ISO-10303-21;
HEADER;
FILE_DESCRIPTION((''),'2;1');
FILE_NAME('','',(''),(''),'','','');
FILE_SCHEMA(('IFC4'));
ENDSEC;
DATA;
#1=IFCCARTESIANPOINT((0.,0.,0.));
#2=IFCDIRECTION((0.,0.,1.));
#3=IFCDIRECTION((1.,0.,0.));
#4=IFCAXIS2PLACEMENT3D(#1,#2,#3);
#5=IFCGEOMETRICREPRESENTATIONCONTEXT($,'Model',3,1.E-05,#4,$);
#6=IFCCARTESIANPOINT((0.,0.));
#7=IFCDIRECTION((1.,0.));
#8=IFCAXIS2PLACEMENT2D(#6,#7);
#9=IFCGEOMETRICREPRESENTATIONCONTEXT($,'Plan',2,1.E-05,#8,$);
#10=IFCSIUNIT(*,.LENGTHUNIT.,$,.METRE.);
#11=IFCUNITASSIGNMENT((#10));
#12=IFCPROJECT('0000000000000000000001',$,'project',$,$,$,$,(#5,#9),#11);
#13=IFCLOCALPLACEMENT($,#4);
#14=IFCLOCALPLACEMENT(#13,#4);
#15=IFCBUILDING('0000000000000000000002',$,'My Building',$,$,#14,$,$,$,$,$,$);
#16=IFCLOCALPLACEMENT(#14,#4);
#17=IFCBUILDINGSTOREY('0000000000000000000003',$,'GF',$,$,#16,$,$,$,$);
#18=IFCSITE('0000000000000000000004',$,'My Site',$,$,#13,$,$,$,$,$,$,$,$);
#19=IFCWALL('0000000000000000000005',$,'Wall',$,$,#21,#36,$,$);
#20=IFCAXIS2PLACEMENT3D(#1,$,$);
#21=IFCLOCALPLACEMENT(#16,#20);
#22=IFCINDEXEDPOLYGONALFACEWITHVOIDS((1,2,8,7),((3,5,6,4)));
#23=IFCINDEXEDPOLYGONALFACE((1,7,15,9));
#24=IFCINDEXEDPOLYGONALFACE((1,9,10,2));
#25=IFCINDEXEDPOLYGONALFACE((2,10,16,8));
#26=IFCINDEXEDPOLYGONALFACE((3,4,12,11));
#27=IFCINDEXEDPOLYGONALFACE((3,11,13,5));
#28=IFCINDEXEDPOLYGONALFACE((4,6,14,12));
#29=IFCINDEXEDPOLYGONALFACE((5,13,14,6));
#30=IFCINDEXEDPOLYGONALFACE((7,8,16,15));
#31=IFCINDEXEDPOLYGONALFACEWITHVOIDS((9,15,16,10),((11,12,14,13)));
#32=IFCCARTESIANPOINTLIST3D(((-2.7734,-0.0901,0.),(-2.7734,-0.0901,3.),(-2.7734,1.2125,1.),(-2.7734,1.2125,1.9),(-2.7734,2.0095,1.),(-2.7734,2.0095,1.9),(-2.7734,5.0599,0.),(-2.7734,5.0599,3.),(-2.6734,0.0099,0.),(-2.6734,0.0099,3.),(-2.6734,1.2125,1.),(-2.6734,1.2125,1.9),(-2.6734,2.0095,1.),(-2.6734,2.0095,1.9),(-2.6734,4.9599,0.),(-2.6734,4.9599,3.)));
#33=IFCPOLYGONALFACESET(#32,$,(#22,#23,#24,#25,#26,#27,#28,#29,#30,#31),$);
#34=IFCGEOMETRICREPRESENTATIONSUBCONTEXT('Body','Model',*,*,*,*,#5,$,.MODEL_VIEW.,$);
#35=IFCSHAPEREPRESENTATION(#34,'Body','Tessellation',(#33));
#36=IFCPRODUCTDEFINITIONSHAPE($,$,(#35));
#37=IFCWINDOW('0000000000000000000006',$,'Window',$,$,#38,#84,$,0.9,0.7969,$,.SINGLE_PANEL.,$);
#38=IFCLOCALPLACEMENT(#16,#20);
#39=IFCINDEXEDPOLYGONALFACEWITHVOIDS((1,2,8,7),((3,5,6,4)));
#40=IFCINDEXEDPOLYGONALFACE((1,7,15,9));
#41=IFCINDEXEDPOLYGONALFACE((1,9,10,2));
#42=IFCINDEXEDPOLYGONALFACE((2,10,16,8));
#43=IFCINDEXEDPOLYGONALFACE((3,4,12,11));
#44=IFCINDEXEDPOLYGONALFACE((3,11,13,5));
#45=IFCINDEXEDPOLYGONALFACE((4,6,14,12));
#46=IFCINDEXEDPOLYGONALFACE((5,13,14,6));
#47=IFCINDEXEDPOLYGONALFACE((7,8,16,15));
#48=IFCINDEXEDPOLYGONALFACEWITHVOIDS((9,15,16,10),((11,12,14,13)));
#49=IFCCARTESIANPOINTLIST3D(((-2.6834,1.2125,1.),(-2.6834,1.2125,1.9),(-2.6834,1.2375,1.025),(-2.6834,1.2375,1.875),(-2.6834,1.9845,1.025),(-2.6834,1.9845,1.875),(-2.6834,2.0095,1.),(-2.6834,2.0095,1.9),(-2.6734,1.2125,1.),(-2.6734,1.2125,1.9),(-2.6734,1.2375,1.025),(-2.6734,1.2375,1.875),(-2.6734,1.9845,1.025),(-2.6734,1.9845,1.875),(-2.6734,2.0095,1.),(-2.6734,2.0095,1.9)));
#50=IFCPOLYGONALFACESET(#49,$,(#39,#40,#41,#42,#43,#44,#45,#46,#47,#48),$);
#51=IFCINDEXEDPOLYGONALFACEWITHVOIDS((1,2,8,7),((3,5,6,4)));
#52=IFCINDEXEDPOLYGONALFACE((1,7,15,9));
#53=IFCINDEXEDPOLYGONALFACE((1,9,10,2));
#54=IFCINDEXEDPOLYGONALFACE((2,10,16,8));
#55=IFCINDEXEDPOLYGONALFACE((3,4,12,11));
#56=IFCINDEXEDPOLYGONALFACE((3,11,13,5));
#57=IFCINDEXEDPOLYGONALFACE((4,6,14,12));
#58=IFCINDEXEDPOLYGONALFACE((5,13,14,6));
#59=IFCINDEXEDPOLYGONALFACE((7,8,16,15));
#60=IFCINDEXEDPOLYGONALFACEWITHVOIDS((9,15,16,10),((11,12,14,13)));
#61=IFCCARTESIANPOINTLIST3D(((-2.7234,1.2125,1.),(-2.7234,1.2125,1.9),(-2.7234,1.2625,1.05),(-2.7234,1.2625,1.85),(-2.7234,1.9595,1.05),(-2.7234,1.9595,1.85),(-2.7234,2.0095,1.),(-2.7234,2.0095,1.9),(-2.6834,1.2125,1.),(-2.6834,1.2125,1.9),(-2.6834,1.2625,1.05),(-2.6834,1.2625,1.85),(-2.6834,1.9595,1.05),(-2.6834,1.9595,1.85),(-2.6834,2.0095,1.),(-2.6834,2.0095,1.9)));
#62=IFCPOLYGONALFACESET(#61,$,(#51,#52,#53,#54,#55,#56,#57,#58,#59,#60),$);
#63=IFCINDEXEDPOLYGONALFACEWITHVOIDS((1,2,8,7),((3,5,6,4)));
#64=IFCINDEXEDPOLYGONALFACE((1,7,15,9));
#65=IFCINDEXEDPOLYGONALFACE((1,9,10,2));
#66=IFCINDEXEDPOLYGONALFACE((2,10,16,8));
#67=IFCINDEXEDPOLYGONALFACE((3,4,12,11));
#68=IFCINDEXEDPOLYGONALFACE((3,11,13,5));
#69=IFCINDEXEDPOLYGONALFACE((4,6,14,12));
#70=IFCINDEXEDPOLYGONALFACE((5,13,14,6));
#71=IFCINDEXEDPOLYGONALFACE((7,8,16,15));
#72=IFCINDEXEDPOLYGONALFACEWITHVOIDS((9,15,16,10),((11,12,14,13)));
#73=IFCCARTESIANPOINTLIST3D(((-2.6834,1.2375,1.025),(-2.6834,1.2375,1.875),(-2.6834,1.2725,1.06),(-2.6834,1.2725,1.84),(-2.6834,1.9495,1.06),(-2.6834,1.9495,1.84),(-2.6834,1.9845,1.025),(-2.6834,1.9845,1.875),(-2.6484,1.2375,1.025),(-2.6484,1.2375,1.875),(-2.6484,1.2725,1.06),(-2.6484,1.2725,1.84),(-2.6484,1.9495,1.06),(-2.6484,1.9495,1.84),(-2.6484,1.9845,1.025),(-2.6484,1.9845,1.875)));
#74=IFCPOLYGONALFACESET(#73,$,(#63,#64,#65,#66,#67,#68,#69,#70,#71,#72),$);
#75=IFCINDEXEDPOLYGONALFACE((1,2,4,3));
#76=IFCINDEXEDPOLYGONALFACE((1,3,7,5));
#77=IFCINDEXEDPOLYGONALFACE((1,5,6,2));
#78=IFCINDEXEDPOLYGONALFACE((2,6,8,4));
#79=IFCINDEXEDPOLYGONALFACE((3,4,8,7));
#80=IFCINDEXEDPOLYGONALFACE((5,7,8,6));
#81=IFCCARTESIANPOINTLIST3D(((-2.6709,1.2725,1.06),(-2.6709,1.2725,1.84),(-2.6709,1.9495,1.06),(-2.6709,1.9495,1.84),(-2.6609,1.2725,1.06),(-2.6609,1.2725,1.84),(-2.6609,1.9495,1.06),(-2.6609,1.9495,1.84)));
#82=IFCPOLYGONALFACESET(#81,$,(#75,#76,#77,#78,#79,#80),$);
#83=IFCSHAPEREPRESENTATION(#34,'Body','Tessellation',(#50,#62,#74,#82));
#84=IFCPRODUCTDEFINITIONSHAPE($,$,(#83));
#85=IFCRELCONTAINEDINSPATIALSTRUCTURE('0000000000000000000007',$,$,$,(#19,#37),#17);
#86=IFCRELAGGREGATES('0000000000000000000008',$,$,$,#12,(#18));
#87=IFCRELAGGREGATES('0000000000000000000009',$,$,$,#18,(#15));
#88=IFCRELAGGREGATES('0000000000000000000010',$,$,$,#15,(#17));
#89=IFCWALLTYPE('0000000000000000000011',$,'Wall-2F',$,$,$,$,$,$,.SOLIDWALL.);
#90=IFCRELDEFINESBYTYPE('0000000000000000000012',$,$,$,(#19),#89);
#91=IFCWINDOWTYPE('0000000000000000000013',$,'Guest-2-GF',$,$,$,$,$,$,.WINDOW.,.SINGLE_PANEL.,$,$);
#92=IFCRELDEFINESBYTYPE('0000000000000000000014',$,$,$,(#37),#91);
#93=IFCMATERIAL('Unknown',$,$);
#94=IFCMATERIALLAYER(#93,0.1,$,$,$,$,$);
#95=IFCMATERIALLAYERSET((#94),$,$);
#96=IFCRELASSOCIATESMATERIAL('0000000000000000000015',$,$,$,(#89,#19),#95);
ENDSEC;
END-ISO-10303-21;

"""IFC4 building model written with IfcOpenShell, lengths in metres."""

from ifc_helpers import new_model, entity, si_unit, frame, origin_with_axes, origin_2d_with_axis, place, context, subcontext, project, spatial, line, indexed_curve, outline, extrude, shape, source, transform, mapped, material, layer, layer_set, layer_usage, type_object, type_shapes, element, fill, save


model = new_model("IFC4")

# Units and contexts
model_context = context("Model", 3, precision=1e-05, world=origin_with_axes())
plan_context = context("Plan", 2, precision=1e-05, world=origin_2d_with_axis())
body_context_1 = subcontext(model_context, "Body", "Model", "MODEL_VIEW")
body_context_2 = subcontext(plan_context, "Body", "Plan", "PLAN_VIEW")
ifc_project = project(units=[si_unit("LENGTHUNIT", "METRE")], contexts=[model_context, plan_context])

# Site, building, storey
site_placement = place(None, origin_with_axes())
site = spatial("IfcSite", under=ifc_project, at=site_placement, Name="My Site")
building_placement = place(site_placement, origin_with_axes())
building = spatial("IfcBuilding", under=site, at=building_placement, Name="My Building")
storey_placement = place(building_placement, origin_with_axes())
storey = spatial("IfcBuildingStorey", under=building, at=storey_placement, Name="GF")

# Shared definitions
ifc_material_1 = material(Name="Unknown")

# Shared definitions
ifc_layer_1 = layer(ifc_material_1, 0.1)
ifc_layer_set_1 = layer_set([ifc_layer_1])
wall_type = type_object("IfcWallType", Name="Wall-2F", PredefinedType="SOLIDWALL", material=ifc_layer_set_1)

# Wall, opening, window
ifc_layer_usage_1 = layer_usage(ifc_layer_set_1, "AXIS2", "POSITIVE", 0.0)
wall_1_placement = place(storey_placement, frame((-2.7734, 5.0599, 0.0), z_axis=(0.0, 0.0, 1.0), x_axis=(0.0, -1.0, 0.0)))
wall_1 = element("IfcWall", 1, at=wall_1_placement, inside=storey, type_object=wall_type, material=ifc_layer_usage_1, Name="Wall", context=body_context_1, shape_type="SweptSolid", body=[
    extrude(outline(indexed_curve([(0.0, 0.0), (0.1, 0.1), (5.05, 0.1), (5.15, 0.0)], segments=[line(1, 2, 3, 4, 1)])), origin_with_axes(), (0.0, 0.0, 1.0), 3.0),
])
shared_shape_1 = source(origin_with_axes(), body_context_1, "Body", "SweptSolid", [
    extrude(outline(indexed_curve([(0.0, 0.0), (0.7969, 0.0), (0.7969, 0.9), (0.0, 0.9)], segments=[line(1, 2, 3, 4, 1)])), frame((0.0, -0.6, 0.0), z_axis=(0.0, -1.0, 0.0), x_axis=(1.0, 0.0, 0.0)), (0.0, 0.0, -1.0), 1.2),
])
opening_1_placement = place(wall_1_placement, frame((3.0504, 0.0, 1.0), z_axis=(0.0, 0.0, 1.0), x_axis=(1.0, 0.0, 0.0)))
opening_1 = element("IfcOpeningElement", 2, at=opening_1_placement, cuts=wall_1, PredefinedType="OPENING", context=body_context_1, shape_type="MappedRepresentation", body=[
    mapped(shared_shape_1, transform((0.0, 0.0, 0.0), x_axis=(1.0, 0.0, 0.0), y_axis=(0.0, 1.0, 0.0), z_axis=(0.0, 0.0, 1.0), scale=1.0)),
])
window_type_1 = type_object("IfcWindowType", Name="Guest-2-GF", PartitioningType="SINGLE_PANEL", PredefinedType="WINDOW")
shared_shape_2 = source(origin_with_axes(), body_context_1, "Body", "SweptSolid", [
    extrude(outline(indexed_curve([(0.0, 0.0), (0.7969, 0.0), (0.7969, 0.9), (0.0, 0.9)], segments=[line(1, 2, 3, 4, 1)]), holes=[indexed_curve([(0.025, 0.025), (0.7719, 0.025), (0.7719, 0.875), (0.025, 0.875)], segments=[line(1, 2, 3, 4, 1)])]), frame((0.0, 0.09, 0.0), z_axis=(0.0, -1.0, 0.0), x_axis=(1.0, 0.0, 0.0)), (0.0, 0.0, -1.0), 0.01),
    extrude(outline(indexed_curve([(0.0, 0.0), (0.7969, 0.0), (0.7969, 0.9), (0.0, 0.9)], segments=[line(1, 2, 3, 4, 1)]), holes=[indexed_curve([(0.05, 0.05), (0.7469, 0.05), (0.7469, 0.85), (0.05, 0.85)], segments=[line(1, 2, 3, 4, 1)])]), frame((0.0, 0.05, 0.0), z_axis=(0.0, -1.0, 0.0), x_axis=(1.0, 0.0, 0.0)), (0.0, 0.0, -1.0), 0.04),
    extrude(outline(indexed_curve([(0.0, 0.0), (0.7469, 0.0), (0.7469, 0.85), (0.0, 0.85)], segments=[line(1, 2, 3, 4, 1)]), holes=[indexed_curve([(0.035, 0.035), (0.7119, 0.035), (0.7119, 0.815), (0.035, 0.815)], segments=[line(1, 2, 3, 4, 1)])]), frame((0.025, 0.09, 0.025), z_axis=(0.0, -1.0, 0.0), x_axis=(1.0, 0.0, 0.0)), (0.0, 0.0, -1.0), 0.035),
    extrude(outline(indexed_curve([(0.035, 0.035), (0.7119, 0.035), (0.7119, 0.815), (0.035, 0.815)], segments=[line(1, 2, 3, 4, 1)])), frame((0.025, 0.1025, 0.025), z_axis=(0.0, -1.0, 0.0), x_axis=(1.0, 0.0, 0.0)), (0.0, 0.0, -1.0), 0.01),
])
shared_shape_3 = source(origin_with_axes(), body_context_2, "Body", "Curve2D", [
    entity("IfcIndexedPolyCurve", entity("IfcCartesianPointList2D", [[0.05, 0.05], [0.7469, 0.05]])),
    entity("IfcIndexedPolyCurve", entity("IfcCartesianPointList2D", [[0.0, 0.1], [0.025, 0.1], [0.025, 0.09], [0.05, 0.09], [0.05, 0.05], [0.0, 0.05]]), [entity("IfcLineIndex", [1, 2, 3, 4, 5, 6, 1])]),
    entity("IfcIndexedPolyCurve", entity("IfcCartesianPointList2D", [[0.7969, 0.1], [0.7719, 0.1], [0.7719, 0.09], [0.7469, 0.09], [0.7469, 0.05], [0.7969, 0.05]]), [entity("IfcLineIndex", [1, 2, 3, 4, 5, 6, 1])]),
    entity("IfcIndexedPolyCurve", entity("IfcCartesianPointList2D", [[0.025, 0.09], [0.06, 0.09], [0.06, 0.125], [0.025, 0.125]]), [entity("IfcLineIndex", [1, 2, 3, 4, 1])]),
    entity("IfcIndexedPolyCurve", entity("IfcCartesianPointList2D", [[0.7719, 0.09], [0.7369, 0.09], [0.7369, 0.125], [0.7719, 0.125]]), [entity("IfcLineIndex", [1, 2, 3, 4, 1])]),
    entity("IfcIndexedPolyCurve", entity("IfcCartesianPointList2D", [[0.06, 0.09], [0.7369, 0.09]])),
    entity("IfcIndexedPolyCurve", entity("IfcCartesianPointList2D", [[0.06, 0.125], [0.7369, 0.125]])),
    entity("IfcIndexedPolyCurve", entity("IfcCartesianPointList2D", [[0.06, 0.1075], [0.7369, 0.1075]])),
])
type_shapes(window_type_1, [shared_shape_2, shared_shape_3])
window_1_placement = place(opening_1_placement, frame((0.0, 0.0, 0.0), z_axis=(0.0, 0.0, 1.0), x_axis=(1.0, 0.0, 0.0)))
window_1 = element("IfcWindow", 3, at=window_1_placement, inside=storey, type_object=window_type_1, Name="Window", OverallHeight=0.9, OverallWidth=0.7969, PartitioningType="SINGLE_PANEL", shapes=[
    shape(body_context_1, "Body", "MappedRepresentation", [mapped(shared_shape_2, transform((0.0, 0.0, 0.0), x_axis=(1.0, 0.0, 0.0), y_axis=(0.0, 1.0, 0.0), z_axis=(0.0, 0.0, 1.0), scale=1.0))]),
    shape(body_context_2, "Body", "MappedRepresentation", [mapped(shared_shape_3, transform((0.0, 0.0, 0.0), x_axis=(1.0, 0.0, 0.0), y_axis=(0.0, 1.0, 0.0), z_axis=(0.0, 0.0, 1.0), scale=1.0))]),
])
fill(opening_1, window_1)

save(model, "model.ifc")
